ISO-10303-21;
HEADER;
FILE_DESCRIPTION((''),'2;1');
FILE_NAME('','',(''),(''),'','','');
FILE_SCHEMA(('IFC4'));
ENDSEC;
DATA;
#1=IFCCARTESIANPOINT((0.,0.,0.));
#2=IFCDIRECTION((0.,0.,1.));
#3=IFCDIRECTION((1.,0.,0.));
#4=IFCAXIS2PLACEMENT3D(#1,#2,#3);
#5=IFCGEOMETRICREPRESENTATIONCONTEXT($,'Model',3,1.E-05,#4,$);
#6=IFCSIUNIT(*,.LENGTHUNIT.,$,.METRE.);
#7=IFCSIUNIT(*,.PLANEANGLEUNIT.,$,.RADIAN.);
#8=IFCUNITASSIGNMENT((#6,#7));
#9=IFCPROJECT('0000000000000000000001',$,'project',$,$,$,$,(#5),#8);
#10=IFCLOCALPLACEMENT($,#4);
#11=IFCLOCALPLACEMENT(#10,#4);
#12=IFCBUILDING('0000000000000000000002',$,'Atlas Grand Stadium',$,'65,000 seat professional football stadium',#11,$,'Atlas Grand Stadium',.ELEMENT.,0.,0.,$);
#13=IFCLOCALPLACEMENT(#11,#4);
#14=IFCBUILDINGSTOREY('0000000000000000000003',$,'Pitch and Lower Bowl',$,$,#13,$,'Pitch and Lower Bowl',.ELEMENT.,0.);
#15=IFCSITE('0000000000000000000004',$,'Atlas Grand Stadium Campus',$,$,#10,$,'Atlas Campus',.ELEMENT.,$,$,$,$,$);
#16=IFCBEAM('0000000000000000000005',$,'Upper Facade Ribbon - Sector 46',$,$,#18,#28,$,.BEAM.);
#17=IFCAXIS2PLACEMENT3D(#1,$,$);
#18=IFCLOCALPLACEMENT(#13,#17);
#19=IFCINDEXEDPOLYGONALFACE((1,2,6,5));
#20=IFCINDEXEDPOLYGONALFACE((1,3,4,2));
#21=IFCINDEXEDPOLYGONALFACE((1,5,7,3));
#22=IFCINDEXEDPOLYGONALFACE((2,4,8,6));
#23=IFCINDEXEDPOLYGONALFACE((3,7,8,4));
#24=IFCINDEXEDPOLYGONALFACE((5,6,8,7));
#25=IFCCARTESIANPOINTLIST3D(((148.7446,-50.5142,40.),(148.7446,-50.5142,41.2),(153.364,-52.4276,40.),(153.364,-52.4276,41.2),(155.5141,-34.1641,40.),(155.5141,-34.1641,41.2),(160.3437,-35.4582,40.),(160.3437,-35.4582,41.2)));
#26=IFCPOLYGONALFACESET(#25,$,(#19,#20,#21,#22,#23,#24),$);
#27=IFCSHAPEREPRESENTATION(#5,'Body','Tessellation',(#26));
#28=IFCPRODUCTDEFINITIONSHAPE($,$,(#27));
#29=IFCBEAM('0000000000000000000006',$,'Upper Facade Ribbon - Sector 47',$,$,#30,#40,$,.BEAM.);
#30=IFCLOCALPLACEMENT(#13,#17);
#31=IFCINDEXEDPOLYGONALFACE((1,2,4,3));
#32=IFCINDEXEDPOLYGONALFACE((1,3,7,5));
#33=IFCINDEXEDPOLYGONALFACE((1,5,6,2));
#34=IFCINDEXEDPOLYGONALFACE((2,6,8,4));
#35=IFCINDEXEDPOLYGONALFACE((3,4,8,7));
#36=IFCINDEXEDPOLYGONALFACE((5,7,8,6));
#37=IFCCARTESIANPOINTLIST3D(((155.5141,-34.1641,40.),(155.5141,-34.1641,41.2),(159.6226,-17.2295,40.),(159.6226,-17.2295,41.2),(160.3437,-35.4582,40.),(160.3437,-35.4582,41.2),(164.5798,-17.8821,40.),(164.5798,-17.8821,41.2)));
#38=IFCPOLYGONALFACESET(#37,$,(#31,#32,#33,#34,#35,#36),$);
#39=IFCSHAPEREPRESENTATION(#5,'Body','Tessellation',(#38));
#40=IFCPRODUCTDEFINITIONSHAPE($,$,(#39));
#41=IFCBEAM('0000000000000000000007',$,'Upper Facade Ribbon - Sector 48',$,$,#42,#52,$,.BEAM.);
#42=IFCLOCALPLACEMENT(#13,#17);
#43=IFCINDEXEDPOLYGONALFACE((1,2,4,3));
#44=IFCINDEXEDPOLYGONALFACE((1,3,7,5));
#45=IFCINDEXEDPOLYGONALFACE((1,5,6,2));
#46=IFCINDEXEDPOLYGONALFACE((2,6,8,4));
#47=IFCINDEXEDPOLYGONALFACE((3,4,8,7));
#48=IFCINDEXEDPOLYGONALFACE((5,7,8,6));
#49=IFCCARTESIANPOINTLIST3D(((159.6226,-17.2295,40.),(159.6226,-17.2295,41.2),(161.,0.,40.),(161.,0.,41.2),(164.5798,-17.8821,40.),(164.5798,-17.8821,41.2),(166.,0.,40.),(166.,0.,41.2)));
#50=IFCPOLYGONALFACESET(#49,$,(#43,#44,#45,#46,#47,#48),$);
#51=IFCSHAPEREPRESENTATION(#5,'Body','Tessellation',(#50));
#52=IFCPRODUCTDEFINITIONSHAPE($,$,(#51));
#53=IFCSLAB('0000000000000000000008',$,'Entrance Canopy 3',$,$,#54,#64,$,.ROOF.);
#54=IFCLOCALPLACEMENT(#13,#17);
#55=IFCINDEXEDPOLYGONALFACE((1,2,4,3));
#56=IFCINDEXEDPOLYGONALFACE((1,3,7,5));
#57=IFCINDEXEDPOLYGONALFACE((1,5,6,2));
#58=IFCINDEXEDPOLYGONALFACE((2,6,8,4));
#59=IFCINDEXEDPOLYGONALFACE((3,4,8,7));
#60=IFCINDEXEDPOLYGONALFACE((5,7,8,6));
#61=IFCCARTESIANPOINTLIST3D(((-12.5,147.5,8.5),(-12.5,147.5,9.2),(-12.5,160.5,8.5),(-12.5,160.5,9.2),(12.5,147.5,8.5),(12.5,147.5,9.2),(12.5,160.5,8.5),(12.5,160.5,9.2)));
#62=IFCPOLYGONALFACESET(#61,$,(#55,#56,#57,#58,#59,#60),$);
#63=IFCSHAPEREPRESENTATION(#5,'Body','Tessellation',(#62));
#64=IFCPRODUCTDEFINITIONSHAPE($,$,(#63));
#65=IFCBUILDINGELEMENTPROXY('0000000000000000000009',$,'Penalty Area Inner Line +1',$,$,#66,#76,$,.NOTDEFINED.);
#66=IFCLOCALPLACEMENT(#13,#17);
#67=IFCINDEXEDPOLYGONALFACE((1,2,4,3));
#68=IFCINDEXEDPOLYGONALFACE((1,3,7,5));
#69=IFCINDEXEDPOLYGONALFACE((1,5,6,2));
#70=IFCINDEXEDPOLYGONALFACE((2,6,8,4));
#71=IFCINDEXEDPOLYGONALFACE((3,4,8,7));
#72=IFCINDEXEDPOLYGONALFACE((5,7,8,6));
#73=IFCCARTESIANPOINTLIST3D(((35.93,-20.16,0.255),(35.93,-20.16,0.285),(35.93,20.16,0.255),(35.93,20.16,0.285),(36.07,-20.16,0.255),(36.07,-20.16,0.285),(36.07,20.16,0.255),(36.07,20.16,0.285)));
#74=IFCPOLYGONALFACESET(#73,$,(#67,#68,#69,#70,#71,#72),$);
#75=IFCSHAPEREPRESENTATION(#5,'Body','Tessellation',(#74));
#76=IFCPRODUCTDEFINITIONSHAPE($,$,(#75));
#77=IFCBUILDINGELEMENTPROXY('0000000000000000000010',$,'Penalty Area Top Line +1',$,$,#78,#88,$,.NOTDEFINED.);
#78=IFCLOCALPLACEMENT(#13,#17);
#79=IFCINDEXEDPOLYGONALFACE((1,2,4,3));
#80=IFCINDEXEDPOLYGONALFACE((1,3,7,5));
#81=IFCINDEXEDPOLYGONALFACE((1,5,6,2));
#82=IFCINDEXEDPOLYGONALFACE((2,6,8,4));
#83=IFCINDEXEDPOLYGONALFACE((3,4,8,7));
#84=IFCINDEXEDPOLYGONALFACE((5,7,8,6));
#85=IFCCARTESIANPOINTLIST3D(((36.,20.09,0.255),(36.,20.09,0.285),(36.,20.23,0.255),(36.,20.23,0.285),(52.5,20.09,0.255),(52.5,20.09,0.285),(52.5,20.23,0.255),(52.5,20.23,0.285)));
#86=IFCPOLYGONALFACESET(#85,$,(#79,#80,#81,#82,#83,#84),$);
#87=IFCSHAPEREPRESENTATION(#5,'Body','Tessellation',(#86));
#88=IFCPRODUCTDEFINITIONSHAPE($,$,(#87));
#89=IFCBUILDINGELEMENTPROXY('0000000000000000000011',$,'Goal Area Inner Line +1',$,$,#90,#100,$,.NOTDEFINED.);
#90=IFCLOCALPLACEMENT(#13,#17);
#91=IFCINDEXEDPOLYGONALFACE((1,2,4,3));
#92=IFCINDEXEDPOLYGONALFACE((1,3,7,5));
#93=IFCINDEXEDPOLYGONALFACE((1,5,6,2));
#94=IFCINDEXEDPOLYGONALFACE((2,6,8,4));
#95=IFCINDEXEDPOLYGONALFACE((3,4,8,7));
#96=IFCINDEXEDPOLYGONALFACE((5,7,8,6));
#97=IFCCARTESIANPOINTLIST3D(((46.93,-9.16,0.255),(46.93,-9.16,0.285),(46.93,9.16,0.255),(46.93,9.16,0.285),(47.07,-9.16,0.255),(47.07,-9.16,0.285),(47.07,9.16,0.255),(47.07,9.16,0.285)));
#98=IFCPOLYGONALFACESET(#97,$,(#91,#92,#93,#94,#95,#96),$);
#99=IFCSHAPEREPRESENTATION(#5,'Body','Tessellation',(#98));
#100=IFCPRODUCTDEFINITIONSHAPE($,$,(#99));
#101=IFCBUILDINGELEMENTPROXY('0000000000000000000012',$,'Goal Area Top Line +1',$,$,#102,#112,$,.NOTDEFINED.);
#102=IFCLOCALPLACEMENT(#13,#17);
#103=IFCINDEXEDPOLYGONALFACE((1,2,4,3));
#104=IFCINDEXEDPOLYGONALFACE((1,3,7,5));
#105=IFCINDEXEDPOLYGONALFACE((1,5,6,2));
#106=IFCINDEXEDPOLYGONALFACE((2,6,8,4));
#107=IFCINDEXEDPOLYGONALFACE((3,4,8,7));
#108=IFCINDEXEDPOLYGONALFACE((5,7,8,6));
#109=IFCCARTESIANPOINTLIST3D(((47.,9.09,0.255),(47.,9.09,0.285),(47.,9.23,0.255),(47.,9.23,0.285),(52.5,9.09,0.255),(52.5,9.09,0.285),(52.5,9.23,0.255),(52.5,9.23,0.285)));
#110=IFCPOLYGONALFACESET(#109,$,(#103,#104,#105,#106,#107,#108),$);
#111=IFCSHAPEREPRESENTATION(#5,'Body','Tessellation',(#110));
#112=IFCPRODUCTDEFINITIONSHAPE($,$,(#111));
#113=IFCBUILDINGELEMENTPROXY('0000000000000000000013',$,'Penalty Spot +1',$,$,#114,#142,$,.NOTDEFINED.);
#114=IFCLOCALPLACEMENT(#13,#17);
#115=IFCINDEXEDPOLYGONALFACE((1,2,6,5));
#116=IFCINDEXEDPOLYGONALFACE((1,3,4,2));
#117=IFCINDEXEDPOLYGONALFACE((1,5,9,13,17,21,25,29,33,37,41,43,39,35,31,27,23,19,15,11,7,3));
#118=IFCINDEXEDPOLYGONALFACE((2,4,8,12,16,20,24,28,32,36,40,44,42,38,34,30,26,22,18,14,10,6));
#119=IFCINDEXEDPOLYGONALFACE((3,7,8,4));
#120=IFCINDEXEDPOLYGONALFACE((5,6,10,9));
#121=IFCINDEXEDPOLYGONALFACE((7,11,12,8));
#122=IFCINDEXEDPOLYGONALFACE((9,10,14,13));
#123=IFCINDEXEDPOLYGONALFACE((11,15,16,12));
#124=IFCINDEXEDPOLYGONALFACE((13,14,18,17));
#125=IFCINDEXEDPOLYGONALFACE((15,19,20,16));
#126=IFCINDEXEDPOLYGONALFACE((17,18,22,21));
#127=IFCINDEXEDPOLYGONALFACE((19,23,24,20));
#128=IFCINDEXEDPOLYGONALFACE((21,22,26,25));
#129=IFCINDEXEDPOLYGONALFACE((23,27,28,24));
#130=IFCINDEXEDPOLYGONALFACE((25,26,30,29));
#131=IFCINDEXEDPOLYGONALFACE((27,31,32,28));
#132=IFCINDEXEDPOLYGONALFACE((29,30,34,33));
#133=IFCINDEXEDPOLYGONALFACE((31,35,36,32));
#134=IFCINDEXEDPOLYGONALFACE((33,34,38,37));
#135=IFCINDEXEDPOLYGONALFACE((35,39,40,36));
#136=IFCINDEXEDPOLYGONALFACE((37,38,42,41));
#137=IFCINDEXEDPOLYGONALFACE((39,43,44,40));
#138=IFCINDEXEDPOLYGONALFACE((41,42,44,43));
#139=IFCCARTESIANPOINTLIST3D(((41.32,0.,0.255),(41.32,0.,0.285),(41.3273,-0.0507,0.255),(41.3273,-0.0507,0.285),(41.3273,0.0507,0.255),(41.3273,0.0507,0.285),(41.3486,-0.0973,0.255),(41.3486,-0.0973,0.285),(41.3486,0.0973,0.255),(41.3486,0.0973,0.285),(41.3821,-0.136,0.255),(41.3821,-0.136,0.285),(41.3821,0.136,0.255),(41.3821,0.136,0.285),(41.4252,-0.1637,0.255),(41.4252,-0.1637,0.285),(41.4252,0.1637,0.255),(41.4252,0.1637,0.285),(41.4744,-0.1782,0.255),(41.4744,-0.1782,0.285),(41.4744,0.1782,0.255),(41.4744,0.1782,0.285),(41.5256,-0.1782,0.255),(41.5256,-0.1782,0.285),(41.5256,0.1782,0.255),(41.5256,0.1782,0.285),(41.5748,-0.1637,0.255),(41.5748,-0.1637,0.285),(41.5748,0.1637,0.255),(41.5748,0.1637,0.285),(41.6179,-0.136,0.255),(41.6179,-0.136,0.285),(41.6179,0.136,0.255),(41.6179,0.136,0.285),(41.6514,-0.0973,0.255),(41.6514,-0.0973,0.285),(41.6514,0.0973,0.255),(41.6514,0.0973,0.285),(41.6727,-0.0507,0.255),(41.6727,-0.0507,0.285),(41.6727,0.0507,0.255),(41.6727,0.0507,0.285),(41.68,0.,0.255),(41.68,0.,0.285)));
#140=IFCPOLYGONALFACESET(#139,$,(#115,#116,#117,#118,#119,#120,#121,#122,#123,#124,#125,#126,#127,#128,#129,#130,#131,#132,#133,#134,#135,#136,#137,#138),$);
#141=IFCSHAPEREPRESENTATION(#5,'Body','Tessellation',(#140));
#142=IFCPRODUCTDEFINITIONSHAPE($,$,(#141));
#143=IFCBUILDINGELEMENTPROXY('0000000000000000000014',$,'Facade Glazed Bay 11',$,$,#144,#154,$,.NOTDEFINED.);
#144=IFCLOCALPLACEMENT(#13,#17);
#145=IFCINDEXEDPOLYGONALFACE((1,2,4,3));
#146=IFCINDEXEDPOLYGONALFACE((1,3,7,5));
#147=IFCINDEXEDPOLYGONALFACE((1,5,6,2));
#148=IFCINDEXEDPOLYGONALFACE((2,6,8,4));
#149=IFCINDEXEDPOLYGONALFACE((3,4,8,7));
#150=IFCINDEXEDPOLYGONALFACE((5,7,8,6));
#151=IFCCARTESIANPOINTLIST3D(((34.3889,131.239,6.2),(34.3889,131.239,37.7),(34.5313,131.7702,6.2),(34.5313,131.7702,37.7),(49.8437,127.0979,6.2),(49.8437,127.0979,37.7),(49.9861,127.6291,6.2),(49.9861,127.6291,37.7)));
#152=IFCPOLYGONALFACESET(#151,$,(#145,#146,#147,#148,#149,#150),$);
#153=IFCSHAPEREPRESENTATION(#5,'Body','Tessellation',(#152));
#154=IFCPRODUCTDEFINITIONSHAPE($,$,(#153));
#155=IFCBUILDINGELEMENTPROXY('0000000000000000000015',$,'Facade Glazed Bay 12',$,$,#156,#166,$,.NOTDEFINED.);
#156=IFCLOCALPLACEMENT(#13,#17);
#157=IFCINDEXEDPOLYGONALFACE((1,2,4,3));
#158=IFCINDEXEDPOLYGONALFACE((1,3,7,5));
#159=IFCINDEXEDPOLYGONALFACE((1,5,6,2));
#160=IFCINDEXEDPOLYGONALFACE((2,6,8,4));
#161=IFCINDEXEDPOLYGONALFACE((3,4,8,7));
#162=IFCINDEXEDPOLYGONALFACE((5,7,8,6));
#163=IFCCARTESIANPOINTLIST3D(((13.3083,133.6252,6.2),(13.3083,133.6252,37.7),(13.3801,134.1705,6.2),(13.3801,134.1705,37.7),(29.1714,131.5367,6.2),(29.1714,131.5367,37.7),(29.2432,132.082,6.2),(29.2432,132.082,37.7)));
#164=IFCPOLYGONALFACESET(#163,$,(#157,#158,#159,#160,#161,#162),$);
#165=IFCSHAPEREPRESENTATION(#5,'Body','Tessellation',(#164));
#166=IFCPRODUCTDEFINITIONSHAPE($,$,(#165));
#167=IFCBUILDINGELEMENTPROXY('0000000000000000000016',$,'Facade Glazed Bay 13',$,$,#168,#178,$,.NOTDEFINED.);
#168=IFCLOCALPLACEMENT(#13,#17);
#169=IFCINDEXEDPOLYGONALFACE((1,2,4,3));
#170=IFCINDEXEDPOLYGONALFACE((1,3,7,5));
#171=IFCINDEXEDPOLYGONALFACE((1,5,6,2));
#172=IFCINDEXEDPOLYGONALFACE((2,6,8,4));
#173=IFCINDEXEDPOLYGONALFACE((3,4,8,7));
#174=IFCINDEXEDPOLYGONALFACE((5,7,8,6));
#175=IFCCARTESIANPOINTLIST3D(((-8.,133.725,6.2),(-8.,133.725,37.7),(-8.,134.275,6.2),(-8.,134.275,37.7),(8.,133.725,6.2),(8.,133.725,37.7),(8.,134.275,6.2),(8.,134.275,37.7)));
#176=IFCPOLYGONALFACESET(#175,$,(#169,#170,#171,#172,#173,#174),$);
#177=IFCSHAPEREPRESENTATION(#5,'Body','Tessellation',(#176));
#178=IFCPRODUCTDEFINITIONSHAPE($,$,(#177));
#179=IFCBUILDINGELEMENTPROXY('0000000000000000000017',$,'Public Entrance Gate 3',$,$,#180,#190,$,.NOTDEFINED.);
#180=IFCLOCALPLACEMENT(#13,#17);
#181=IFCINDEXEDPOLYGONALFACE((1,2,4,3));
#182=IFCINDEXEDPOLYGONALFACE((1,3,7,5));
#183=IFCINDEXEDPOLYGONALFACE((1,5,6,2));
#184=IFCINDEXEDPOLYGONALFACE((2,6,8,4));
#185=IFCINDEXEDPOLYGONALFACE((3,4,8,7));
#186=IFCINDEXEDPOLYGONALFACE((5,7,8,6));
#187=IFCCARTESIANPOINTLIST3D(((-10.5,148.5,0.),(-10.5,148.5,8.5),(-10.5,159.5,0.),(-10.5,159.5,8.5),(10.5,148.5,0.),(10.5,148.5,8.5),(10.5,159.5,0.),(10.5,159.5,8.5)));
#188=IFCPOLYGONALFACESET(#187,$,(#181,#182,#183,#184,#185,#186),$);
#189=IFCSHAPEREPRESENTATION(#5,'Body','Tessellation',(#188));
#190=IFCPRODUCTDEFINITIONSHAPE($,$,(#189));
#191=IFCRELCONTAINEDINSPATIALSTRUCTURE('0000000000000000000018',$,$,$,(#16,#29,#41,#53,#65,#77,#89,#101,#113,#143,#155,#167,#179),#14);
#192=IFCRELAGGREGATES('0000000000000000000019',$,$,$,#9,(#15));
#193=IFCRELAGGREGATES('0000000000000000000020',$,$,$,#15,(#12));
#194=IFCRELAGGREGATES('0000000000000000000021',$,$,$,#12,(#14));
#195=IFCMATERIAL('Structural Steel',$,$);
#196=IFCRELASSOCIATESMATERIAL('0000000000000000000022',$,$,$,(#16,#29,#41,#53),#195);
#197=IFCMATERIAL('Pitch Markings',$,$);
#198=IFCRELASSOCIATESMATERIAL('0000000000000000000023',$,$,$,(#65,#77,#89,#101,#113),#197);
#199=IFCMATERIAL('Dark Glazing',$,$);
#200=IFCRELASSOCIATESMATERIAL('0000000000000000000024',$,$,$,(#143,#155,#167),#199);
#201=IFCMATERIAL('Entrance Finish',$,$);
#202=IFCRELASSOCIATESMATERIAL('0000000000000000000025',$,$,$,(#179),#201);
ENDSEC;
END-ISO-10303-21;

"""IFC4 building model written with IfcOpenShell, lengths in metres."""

from ifc_helpers import new_model, si_unit, frame, origin_with_axes, origin_2d_with_axis, place, context, project, spatial, polyline, rectangle, circle, outline, extrude, material, element, save


model = new_model("IFC4")

# Units and contexts
model_context = context("Model", 3, precision=1e-05, world=origin_with_axes())
ifc_project = project(units=[si_unit("LENGTHUNIT", "METRE"), si_unit("PLANEANGLEUNIT", "RADIAN")], contexts=[model_context])

# Site, building, storey
site_placement = place(None, origin_with_axes())
site = spatial("IfcSite", under=ifc_project, at=site_placement, Name="Atlas Grand Stadium Campus", LongName="Atlas Campus", CompositionType="ELEMENT")
building_placement = place(site_placement, origin_with_axes())
building = spatial("IfcBuilding", under=site, at=building_placement, Name="Atlas Grand Stadium", ObjectType="65,000 seat professional football stadium", LongName="Atlas Grand Stadium", CompositionType="ELEMENT", ElevationOfRefHeight=0.0, ElevationOfTerrain=0.0)
storey_placement = place(building_placement, origin_with_axes())
storey = spatial("IfcBuildingStorey", under=building, at=storey_placement, Name="Pitch and Lower Bowl", LongName="Pitch and Lower Bowl", CompositionType="ELEMENT", Elevation=0.0)

# Shared definitions
ifc_material_1 = material(Name="Structural Steel")

# Beams
beam_1_placement = place(storey_placement, frame((0.0, 0.0, 40.0), z_axis=(0.0, 0.0, 1.0), x_axis=(1.0, 0.0, 0.0)))
element("IfcBeam", 1, at=beam_1_placement, inside=storey, material=ifc_material_1, Name="Upper Facade Ribbon - Sector 46", PredefinedType="BEAM", context=model_context, shape_type="SweptSolid", body=[
    extrude(outline(polyline([(153.364, -52.4276), (160.3437, -35.4582), (155.5141, -34.1641), (148.7446, -50.5142), (153.364, -52.4276)])), origin_with_axes(), (0.0, 0.0, 1.0), 1.2),
])
beam_2_placement = place(storey_placement, frame((0.0, 0.0, 40.0), z_axis=(0.0, 0.0, 1.0), x_axis=(1.0, 0.0, 0.0)))
element("IfcBeam", 2, at=beam_2_placement, inside=storey, material=ifc_material_1, Name="Upper Facade Ribbon - Sector 47", PredefinedType="BEAM", context=model_context, shape_type="SweptSolid", body=[
    extrude(outline(polyline([(160.3437, -35.4582), (164.5798, -17.8821), (159.6226, -17.2295), (155.5141, -34.1641), (160.3437, -35.4582)])), origin_with_axes(), (0.0, 0.0, 1.0), 1.2),
])
beam_3_placement = place(storey_placement, frame((0.0, 0.0, 40.0), z_axis=(0.0, 0.0, 1.0), x_axis=(1.0, 0.0, 0.0)))
element("IfcBeam", 3, at=beam_3_placement, inside=storey, material=ifc_material_1, Name="Upper Facade Ribbon - Sector 48", PredefinedType="BEAM", context=model_context, shape_type="SweptSolid", body=[
    extrude(outline(polyline([(164.5798, -17.8821), (166.0, 0.0), (161.0, 0.0), (159.6226, -17.2295), (164.5798, -17.8821)])), origin_with_axes(), (0.0, 0.0, 1.0), 1.2),
])

# Slab
slab_placement = place(storey_placement, frame((0.0, 154.0, 8.5), z_axis=(0.0, 0.0, 1.0), x_axis=(-1.0, 0.0, 0.0)))
element("IfcSlab", 4, at=slab_placement, inside=storey, material=ifc_material_1, Name="Entrance Canopy 3", PredefinedType="ROOF", context=model_context, shape_type="SweptSolid", body=[
    extrude(rectangle(XDim=25.0, YDim=13.0, at=origin_2d_with_axis()), origin_with_axes(), (0.0, 0.0, 1.0), 0.7),
])

# Building element proxies
ifc_material_2 = material(Name="Pitch Markings")
proxy_1_placement = place(storey_placement, frame((36.0, 0.0, 0.255), z_axis=(0.0, 0.0, 1.0), x_axis=(1.0, 0.0, 0.0)))
element("IfcBuildingElementProxy", 5, at=proxy_1_placement, inside=storey, material=ifc_material_2, Name="Penalty Area Inner Line +1", PredefinedType="NOTDEFINED", context=model_context, shape_type="SweptSolid", body=[
    extrude(rectangle(XDim=0.14, YDim=40.32, at=origin_2d_with_axis()), origin_with_axes(), (0.0, 0.0, 1.0), 0.03),
])
proxy_2_placement = place(storey_placement, frame((44.25, 20.16, 0.255), z_axis=(0.0, 0.0, 1.0), x_axis=(1.0, 0.0, 0.0)))
element("IfcBuildingElementProxy", 6, at=proxy_2_placement, inside=storey, material=ifc_material_2, Name="Penalty Area Top Line +1", PredefinedType="NOTDEFINED", context=model_context, shape_type="SweptSolid", body=[
    extrude(rectangle(XDim=16.5, YDim=0.14, at=origin_2d_with_axis()), origin_with_axes(), (0.0, 0.0, 1.0), 0.03),
])
proxy_3_placement = place(storey_placement, frame((47.0, 0.0, 0.255), z_axis=(0.0, 0.0, 1.0), x_axis=(1.0, 0.0, 0.0)))
element("IfcBuildingElementProxy", 7, at=proxy_3_placement, inside=storey, material=ifc_material_2, Name="Goal Area Inner Line +1", PredefinedType="NOTDEFINED", context=model_context, shape_type="SweptSolid", body=[
    extrude(rectangle(XDim=0.14, YDim=18.32, at=origin_2d_with_axis()), origin_with_axes(), (0.0, 0.0, 1.0), 0.03),
])
proxy_4_placement = place(storey_placement, frame((49.75, 9.16, 0.255), z_axis=(0.0, 0.0, 1.0), x_axis=(1.0, 0.0, 0.0)))
element("IfcBuildingElementProxy", 8, at=proxy_4_placement, inside=storey, material=ifc_material_2, Name="Goal Area Top Line +1", PredefinedType="NOTDEFINED", context=model_context, shape_type="SweptSolid", body=[
    extrude(rectangle(XDim=5.5, YDim=0.14, at=origin_2d_with_axis()), origin_with_axes(), (0.0, 0.0, 1.0), 0.03),
])
proxy_5_placement = place(storey_placement, frame((41.5, 0.0, 0.255), z_axis=(0.0, 0.0, 1.0), x_axis=(1.0, 0.0, 0.0)))
element("IfcBuildingElementProxy", 9, at=proxy_5_placement, inside=storey, material=ifc_material_2, Name="Penalty Spot +1", PredefinedType="NOTDEFINED", context=model_context, shape_type="SweptSolid", body=[
    extrude(circle(Radius=0.18, at=origin_2d_with_axis()), origin_with_axes(), (0.0, 0.0, 1.0), 0.03),
])
ifc_material_3 = material(Name="Dark Glazing")
for number, where, z_axis, x_axis, name in (
    (10, (42.1875, 129.4341, 6.2), (0.0, 0.0, 1.0), (-0.96593, 0.25882, 0.0), "Facade Glazed Bay 11"),
    (11, (21.2758, 132.8536, 6.2), (0.0, 0.0, 1.0), (-0.99144, 0.13053, 0.0), "Facade Glazed Bay 12"),
    (12, (0.0, 134.0, 6.2), (0.0, 0.0, 1.0), (-1.0, 0.0, 0.0), "Facade Glazed Bay 13"),
):
    element("IfcBuildingElementProxy", number, at=place(storey_placement, frame(where, z_axis=z_axis, x_axis=x_axis)), inside=storey, material=ifc_material_3, Name=name, PredefinedType="NOTDEFINED", context=model_context, shape_type="SweptSolid", body=[
        extrude(rectangle(XDim=16.0, YDim=0.55, at=origin_2d_with_axis()), origin_with_axes(), (0.0, 0.0, 1.0), 31.5),
    ])
ifc_material_4 = material(Name="Entrance Finish")
proxy_6_placement = place(storey_placement, frame((0.0, 154.0, 0.0), z_axis=(0.0, 0.0, 1.0), x_axis=(-1.0, 0.0, 0.0)))
element("IfcBuildingElementProxy", 13, at=proxy_6_placement, inside=storey, material=ifc_material_4, Name="Public Entrance Gate 3", PredefinedType="NOTDEFINED", context=model_context, shape_type="SweptSolid", body=[
    extrude(rectangle(XDim=21.0, YDim=11.0, at=origin_2d_with_axis()), origin_with_axes(), (0.0, 0.0, 1.0), 8.5),
])

save(model, "model.ifc")
